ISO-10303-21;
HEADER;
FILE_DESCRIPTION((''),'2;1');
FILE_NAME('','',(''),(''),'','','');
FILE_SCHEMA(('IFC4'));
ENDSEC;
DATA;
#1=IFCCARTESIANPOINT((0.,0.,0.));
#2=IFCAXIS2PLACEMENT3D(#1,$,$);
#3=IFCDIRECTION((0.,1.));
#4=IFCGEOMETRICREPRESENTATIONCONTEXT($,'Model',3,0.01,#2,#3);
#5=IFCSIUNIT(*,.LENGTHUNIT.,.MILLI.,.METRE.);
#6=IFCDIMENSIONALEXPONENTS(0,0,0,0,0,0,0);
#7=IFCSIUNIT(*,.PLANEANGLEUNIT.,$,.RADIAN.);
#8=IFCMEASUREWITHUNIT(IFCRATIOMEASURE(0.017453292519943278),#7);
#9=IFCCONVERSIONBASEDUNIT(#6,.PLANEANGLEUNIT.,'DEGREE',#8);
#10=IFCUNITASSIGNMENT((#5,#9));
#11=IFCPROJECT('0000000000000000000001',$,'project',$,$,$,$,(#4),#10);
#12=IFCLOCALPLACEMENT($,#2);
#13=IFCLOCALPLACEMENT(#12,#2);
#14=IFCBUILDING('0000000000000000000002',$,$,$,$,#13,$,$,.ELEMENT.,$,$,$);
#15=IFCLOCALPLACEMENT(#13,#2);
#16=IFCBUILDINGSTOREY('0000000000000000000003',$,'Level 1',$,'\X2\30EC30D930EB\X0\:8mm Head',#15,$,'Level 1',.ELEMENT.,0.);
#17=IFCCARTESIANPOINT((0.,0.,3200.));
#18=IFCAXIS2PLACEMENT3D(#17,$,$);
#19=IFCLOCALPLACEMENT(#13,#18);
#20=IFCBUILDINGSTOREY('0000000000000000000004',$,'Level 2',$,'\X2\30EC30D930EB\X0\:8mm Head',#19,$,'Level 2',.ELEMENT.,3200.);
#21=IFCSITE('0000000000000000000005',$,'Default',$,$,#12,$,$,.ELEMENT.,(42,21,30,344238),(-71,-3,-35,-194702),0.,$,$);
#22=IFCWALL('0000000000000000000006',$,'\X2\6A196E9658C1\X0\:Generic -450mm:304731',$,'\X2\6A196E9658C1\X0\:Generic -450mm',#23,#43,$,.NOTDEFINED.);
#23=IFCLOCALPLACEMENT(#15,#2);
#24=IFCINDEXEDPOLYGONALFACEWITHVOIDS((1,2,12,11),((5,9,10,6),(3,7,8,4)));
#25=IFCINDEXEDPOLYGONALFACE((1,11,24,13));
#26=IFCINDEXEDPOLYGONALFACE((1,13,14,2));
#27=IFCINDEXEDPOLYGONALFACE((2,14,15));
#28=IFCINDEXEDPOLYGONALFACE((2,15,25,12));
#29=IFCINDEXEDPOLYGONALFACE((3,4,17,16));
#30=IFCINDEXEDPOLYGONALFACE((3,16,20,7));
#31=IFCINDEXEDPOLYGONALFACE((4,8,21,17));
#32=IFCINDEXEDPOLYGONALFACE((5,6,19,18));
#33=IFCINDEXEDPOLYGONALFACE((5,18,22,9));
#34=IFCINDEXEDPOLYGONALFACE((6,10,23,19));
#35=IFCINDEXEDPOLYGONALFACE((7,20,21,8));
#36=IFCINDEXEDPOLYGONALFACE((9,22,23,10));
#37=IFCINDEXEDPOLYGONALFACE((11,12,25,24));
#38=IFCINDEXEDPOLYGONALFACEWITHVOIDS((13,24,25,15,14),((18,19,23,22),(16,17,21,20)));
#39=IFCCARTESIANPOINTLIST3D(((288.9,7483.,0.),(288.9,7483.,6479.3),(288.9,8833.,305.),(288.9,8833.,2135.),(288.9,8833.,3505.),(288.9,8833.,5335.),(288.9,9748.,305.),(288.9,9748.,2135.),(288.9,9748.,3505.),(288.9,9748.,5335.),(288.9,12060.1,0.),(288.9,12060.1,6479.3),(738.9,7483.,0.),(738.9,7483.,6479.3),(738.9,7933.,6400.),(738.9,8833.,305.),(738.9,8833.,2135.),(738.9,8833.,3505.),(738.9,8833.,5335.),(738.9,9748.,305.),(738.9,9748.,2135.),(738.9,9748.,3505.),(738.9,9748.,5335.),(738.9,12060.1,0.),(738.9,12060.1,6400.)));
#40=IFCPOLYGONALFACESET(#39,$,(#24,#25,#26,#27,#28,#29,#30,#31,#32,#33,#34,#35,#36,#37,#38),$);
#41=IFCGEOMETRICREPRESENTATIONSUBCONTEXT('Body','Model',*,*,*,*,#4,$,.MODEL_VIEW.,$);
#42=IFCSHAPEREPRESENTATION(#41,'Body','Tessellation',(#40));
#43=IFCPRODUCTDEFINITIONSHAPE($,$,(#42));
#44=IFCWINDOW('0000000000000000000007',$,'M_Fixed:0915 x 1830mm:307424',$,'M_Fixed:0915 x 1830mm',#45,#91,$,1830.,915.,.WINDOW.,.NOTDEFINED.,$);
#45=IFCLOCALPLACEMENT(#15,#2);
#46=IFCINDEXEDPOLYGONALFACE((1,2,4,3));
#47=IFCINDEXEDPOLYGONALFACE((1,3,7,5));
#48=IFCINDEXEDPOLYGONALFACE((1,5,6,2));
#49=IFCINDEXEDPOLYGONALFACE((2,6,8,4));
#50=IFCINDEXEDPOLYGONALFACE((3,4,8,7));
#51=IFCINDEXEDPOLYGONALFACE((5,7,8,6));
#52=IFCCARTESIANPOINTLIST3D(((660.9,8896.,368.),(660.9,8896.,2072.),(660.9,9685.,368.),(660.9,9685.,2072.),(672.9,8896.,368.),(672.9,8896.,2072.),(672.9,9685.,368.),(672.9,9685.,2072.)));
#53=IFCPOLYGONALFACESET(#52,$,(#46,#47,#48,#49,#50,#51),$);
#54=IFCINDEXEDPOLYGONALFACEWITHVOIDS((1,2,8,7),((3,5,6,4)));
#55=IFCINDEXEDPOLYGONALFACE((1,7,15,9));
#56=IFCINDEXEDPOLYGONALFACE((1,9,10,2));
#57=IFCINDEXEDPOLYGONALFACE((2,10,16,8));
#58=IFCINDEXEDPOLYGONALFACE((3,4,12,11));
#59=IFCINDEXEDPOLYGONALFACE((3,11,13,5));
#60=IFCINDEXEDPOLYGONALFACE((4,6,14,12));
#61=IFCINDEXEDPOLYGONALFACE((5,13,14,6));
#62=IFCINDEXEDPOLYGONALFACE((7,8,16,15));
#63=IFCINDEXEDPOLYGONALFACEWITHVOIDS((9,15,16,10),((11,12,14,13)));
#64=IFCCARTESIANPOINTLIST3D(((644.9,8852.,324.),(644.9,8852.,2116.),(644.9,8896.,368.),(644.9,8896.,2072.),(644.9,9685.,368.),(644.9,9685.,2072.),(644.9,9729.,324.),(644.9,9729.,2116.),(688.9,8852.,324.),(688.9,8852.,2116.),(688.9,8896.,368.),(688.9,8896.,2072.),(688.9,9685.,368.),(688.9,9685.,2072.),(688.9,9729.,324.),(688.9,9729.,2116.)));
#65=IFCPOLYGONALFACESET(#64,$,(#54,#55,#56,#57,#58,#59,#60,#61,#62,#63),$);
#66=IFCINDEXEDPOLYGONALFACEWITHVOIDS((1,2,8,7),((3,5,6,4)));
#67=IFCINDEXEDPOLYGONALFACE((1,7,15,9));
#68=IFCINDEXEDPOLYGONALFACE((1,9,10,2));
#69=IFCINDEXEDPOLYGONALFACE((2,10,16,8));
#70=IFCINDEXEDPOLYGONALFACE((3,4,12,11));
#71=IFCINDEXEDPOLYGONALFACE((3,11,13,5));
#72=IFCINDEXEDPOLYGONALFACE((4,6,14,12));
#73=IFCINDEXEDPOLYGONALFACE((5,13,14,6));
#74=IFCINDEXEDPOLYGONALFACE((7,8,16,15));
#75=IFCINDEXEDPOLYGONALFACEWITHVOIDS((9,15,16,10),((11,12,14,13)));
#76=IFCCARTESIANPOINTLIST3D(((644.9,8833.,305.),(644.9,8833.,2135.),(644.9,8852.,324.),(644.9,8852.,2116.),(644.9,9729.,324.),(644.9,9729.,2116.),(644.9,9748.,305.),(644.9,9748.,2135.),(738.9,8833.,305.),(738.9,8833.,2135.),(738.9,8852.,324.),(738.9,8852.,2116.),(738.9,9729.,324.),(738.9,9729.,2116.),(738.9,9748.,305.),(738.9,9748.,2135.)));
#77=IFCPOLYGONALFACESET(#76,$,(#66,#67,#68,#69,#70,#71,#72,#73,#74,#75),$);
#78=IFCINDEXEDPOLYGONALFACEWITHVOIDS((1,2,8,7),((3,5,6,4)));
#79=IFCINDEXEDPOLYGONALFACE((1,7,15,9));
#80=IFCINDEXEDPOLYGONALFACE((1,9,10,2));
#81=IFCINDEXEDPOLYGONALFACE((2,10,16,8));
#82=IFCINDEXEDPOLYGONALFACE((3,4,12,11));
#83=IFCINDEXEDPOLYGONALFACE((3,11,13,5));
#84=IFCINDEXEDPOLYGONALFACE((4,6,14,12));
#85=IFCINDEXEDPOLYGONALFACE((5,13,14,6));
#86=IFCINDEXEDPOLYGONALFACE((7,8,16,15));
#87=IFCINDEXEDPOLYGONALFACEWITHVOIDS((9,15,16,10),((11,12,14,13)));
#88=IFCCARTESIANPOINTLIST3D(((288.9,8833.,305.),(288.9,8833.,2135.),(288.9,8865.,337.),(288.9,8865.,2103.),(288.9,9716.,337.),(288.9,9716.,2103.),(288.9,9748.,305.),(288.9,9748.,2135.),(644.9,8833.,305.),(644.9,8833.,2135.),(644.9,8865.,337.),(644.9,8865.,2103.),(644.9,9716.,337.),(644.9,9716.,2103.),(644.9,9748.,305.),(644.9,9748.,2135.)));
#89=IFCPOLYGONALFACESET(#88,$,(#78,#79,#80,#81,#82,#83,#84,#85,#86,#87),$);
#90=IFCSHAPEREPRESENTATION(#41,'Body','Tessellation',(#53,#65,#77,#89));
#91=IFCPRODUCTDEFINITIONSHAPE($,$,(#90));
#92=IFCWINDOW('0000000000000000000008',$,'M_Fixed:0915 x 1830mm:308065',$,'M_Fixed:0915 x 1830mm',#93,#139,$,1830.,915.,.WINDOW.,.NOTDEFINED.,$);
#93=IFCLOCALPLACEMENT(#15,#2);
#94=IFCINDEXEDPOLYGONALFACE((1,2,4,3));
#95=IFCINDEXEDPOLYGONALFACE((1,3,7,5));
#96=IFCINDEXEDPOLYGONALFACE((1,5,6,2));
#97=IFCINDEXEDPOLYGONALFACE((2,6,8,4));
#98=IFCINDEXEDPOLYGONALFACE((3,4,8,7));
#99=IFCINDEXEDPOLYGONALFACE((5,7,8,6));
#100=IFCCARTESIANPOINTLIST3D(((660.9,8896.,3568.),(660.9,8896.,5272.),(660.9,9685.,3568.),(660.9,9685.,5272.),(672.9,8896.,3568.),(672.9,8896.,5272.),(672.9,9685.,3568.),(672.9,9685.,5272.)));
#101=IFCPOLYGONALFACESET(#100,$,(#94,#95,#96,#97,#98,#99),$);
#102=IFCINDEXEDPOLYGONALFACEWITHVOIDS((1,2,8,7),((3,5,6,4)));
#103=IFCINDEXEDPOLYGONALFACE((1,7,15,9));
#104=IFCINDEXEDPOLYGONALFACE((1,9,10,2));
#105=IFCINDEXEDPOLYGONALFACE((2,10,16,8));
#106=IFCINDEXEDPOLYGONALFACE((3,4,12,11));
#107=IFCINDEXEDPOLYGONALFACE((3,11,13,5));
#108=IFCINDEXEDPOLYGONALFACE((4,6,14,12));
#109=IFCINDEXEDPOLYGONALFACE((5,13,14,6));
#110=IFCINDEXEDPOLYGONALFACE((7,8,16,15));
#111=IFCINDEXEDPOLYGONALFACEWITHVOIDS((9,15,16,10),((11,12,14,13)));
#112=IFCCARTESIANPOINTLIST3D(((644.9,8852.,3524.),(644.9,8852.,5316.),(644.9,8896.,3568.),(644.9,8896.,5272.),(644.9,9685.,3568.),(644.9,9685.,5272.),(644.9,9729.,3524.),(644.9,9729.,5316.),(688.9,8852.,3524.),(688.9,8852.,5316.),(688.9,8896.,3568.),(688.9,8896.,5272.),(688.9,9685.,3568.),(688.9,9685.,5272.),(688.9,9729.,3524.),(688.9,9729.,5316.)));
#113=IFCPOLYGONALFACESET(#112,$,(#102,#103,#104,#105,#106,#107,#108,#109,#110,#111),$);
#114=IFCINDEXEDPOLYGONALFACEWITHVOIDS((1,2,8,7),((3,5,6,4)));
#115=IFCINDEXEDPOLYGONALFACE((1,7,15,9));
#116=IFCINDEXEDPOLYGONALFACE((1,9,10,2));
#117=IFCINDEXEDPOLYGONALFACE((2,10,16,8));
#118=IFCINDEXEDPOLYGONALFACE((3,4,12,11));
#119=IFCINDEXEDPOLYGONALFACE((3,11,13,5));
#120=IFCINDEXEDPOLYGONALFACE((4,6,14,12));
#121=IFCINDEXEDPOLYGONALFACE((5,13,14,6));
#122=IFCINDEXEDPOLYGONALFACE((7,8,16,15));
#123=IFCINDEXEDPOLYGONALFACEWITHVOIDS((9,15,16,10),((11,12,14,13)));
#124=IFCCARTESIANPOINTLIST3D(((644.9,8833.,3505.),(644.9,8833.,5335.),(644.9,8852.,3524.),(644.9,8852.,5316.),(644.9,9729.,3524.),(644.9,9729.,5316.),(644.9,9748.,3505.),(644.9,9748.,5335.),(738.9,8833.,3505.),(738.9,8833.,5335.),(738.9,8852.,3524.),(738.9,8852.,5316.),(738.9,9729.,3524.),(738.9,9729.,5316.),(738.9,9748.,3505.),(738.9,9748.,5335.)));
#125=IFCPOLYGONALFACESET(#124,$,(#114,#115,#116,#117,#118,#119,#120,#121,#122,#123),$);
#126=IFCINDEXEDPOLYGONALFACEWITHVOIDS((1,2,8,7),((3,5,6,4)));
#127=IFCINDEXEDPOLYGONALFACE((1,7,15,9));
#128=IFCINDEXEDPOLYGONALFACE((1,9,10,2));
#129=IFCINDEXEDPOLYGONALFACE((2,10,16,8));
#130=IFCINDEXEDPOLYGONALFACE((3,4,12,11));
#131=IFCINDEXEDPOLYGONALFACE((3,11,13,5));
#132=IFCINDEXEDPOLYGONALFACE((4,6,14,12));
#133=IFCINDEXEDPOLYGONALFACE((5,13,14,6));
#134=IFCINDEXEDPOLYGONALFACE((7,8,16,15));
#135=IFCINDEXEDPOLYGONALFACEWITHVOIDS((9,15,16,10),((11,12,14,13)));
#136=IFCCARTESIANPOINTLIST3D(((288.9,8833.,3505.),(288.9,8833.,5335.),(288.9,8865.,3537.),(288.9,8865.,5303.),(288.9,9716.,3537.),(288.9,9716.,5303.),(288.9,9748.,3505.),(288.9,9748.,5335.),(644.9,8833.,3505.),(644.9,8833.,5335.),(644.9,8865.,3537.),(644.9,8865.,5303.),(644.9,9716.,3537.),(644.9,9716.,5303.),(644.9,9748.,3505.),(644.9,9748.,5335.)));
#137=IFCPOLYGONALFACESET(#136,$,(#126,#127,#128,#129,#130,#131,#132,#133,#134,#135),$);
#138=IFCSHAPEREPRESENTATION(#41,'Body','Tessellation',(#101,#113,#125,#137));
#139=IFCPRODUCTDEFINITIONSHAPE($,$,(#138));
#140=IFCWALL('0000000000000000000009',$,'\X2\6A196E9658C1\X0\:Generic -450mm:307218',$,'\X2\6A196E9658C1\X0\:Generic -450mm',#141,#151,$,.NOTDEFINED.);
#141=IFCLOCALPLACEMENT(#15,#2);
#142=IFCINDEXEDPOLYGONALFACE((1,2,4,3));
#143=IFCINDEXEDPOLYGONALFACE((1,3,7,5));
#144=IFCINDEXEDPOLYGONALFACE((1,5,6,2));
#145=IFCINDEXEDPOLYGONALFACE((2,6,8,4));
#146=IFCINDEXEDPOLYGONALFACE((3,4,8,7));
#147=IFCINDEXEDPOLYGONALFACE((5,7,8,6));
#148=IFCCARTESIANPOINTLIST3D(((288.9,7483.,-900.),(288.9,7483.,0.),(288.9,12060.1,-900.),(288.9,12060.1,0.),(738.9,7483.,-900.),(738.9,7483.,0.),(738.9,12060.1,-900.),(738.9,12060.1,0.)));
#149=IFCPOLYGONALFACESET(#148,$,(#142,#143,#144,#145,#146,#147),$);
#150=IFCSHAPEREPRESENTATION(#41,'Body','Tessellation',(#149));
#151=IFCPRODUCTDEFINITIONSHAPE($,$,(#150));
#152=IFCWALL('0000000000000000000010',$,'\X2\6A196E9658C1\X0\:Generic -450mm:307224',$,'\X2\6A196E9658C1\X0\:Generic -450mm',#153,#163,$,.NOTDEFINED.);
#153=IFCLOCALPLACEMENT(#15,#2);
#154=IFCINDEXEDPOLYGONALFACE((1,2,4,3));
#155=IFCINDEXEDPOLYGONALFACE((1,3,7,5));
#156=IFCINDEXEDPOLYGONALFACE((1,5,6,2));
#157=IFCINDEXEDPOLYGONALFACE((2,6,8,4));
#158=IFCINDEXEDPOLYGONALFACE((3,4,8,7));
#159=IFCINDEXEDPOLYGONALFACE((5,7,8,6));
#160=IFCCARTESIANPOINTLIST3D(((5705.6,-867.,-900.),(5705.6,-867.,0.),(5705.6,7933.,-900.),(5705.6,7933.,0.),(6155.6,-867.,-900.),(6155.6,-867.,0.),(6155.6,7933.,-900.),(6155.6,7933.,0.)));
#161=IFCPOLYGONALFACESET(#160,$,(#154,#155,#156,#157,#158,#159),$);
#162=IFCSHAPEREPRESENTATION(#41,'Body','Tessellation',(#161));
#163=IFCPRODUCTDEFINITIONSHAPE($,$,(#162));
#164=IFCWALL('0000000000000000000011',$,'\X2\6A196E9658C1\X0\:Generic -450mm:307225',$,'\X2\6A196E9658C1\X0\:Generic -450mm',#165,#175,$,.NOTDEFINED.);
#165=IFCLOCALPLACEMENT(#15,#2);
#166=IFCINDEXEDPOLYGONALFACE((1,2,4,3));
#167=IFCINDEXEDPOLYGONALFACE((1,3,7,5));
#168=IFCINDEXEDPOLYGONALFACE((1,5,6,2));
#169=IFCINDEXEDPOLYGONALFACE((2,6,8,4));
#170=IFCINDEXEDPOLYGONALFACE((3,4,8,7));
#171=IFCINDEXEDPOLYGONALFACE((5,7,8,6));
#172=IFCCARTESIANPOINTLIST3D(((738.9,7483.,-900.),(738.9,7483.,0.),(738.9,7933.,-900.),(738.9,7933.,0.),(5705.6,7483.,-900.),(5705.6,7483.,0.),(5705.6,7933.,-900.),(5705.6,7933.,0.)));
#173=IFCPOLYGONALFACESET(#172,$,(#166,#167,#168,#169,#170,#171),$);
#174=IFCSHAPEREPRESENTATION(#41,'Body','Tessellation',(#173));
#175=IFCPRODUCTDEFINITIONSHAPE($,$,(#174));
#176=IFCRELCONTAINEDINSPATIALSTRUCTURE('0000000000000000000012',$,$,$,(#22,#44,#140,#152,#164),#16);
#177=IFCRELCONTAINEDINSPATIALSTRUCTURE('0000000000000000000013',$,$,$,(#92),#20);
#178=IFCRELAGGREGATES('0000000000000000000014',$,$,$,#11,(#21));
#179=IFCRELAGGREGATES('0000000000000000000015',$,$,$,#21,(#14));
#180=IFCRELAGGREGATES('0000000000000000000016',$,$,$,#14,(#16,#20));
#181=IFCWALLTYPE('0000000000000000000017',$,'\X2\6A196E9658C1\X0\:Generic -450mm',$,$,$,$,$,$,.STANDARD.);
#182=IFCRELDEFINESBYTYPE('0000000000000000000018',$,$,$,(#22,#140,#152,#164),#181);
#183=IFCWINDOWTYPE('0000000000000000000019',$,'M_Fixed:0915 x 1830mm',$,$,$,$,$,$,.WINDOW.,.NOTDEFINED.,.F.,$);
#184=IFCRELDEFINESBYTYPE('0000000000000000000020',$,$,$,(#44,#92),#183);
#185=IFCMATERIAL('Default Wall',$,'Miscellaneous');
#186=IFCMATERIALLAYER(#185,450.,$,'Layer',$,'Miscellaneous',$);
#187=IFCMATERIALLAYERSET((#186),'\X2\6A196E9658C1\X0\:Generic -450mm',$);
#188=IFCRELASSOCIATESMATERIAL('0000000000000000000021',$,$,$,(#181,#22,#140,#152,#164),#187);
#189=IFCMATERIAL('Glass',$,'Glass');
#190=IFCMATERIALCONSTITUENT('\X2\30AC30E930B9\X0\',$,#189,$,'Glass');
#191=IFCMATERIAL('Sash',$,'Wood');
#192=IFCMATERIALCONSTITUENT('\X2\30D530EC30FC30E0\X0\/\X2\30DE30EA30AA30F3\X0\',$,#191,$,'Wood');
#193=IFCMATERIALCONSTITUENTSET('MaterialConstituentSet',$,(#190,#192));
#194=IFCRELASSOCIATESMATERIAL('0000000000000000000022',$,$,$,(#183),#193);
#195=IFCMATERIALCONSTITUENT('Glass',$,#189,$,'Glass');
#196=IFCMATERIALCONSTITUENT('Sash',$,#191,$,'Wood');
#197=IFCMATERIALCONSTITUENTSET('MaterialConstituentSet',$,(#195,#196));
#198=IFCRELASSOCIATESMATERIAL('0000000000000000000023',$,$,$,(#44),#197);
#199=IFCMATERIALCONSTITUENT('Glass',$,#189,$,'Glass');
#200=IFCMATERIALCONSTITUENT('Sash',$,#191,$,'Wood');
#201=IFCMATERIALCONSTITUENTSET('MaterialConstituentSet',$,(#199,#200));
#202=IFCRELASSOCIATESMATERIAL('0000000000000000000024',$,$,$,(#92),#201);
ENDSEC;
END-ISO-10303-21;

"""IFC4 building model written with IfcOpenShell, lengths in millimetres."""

from ifc_helpers import new_model, entity, si_unit, converted_unit, direction, frame, frame_2d, origin, origin_2d_with_axis, place, context, subcontext, project, spatial, polyline, rectangle, outline, extrude, clip, bounded_halfspace, source, transform, mapped, material, layer, layer_set, layer_usage, constituent, constituent_set, type_object, type_shapes, element, fill, save


model = new_model("IFC4")

# Units and contexts
model_context = context("Model", 3, precision=0.01, world=origin(), true_north=direction((0.0, 1.0)))
body_context = subcontext(model_context, "Body", "Model", "MODEL_VIEW")
ifc_project = project(units=[si_unit("LENGTHUNIT", "METRE", prefix="MILLI"), converted_unit("PLANEANGLEUNIT", "DEGREE", entity("IfcRatioMeasure", 0.017453292519943278), si_unit("PLANEANGLEUNIT", "RADIAN"), dimensions=[0, 0, 0, 0, 0, 0, 0])], contexts=[model_context])

# Site, building, storey
site_placement = place(None, origin())
site = spatial("IfcSite", under=ifc_project, at=site_placement, Name="Default", CompositionType="ELEMENT", RefLatitude=(42, 21, 30, 344238), RefLongitude=(-71, -3, -35, -194702), RefElevation=0.0)
building_placement = place(site_placement, origin())
building = spatial("IfcBuilding", under=site, at=building_placement, CompositionType="ELEMENT")
storey_1_placement = place(building_placement, origin())
storey_1 = spatial("IfcBuildingStorey", under=building, at=storey_1_placement, Name="Level 1", ObjectType="レベル:8mm Head", LongName="Level 1", CompositionType="ELEMENT", Elevation=0.0)

# Wall, openings, window
ifc_material_1 = material(Name="Default Wall", Category="Miscellaneous")
ifc_layer_1 = layer(ifc_material_1, 450.0, Name="Layer", Category="Miscellaneous")
ifc_layer_set_1 = layer_set([ifc_layer_1], Name="標準壁:Generic -450mm")
ifc_layer_usage_1 = layer_usage(ifc_layer_set_1, "AXIS2", "NEGATIVE", 225.0)
wall_type_1 = type_object("IfcWallType", Name="標準壁:Generic -450mm", PredefinedType="STANDARD", material=ifc_layer_set_1)
wall_1_placement = place(storey_1_placement, frame((513.9, 12060.1, 0.0), z_axis=(0.0, 0.0, 1.0), x_axis=(0.0, -1.0, 0.0)))
wall_1 = element("IfcWall", 1, at=wall_1_placement, inside=storey_1, type_object=wall_type_1, material=ifc_layer_usage_1, Name="標準壁:Generic -450mm:304731", ObjectType="標準壁:Generic -450mm", PredefinedType="NOTDEFINED", context=body_context, shape_type="Clipping", body=[
    clip(clip(extrude(rectangle(XDim=4577.1, YDim=450.0, at=frame_2d((2288.5, 0.0), x_axis=(-1.0, 0.0))), origin(), (0.0, 0.0, 1.0), 6479.3), bounded_halfspace(frame((4577.1, -225.0, 6479.3), z_axis=(-0.173648, 0.0, 0.984808), x_axis=(0.0, -1.0, 0.0)), False, frame((4577.1, -225.0, 6479.3)), polyline([(0.0, 0.0), (0.0, 450.0), (-450.0, 450.0), (0.0, 0.0)]))), bounded_halfspace(frame((0.0, -225.0, 6479.3), z_axis=(0.0, 0.173648, 0.984808), x_axis=(-1.0, 0.0, 0.0)), False, frame((0.0, -225.0, 6479.3)), polyline([(0.0, 0.0), (4577.1, 0.0), (4127.1, 450.0), (0.0, 450.0), (0.0, 0.0)]))),
])
opening_1_placement = place(wall_1_placement, frame((2312.1, -225.0, 305.0)))
opening_1 = element("IfcOpeningElement", 2, at=opening_1_placement, cuts=wall_1, PredefinedType="OPENING", context=body_context, shape_type="SweptSolid", body=[
    extrude(rectangle(XDim=1830.0, YDim=915.0, at=frame_2d((915.0, 457.5), x_axis=(1.0, 0.0))), frame((0.0, 0.0, 0.0), z_axis=(0.0, 1.0, 0.0), x_axis=(0.0, 0.0, 1.0)), (0.0, 0.0, 1.0), 450.0),
])
opening_2_placement = place(wall_1_placement, frame((2312.1, -225.0, 3505.0)))
opening_2 = element("IfcOpeningElement", 3, at=opening_2_placement, cuts=wall_1, PredefinedType="OPENING", context=body_context, shape_type="SweptSolid", body=[
    extrude(rectangle(XDim=1830.0, YDim=915.0, at=frame_2d((915.0, 457.5), x_axis=(1.0, 0.0))), frame((0.0, 0.0, 0.0), z_axis=(0.0, 1.0, 0.0), x_axis=(0.0, 0.0, 1.0)), (0.0, 0.0, 1.0), 450.0),
])
ifc_material_2 = material(Name="Glass", Category="Glass")
ifc_constituent_1 = constituent(ifc_material_2, Name="Glass", Category="Glass")
ifc_material_3 = material(Name="Sash", Category="Wood")
ifc_constituent_2 = constituent(ifc_material_3, Name="Sash", Category="Wood")
ifc_constituent_set_1 = constituent_set(constituents=[ifc_constituent_1, ifc_constituent_2], Name="MaterialConstituentSet")
ifc_constituent_3 = constituent(ifc_material_2, Name="ガラス", Category="Glass")
ifc_constituent_4 = constituent(ifc_material_3, Name="フレーム/マリオン", Category="Wood")
ifc_constituent_set_2 = constituent_set(constituents=[ifc_constituent_3, ifc_constituent_4], Name="MaterialConstituentSet")
window_type_1 = type_object("IfcWindowType", Name="M_Fixed:0915 x 1830mm", ParameterTakesPrecedence=False, PartitioningType="NOTDEFINED", PredefinedType="WINDOW", material=ifc_constituent_set_2)
shared_shape_1 = source(origin(), body_context, "Body", "SweptSolid", [
    extrude(rectangle(XDim=12.0, YDim=789.0, at=origin_2d_with_axis()), frame((457.5, 378.0, 63.0), z_axis=(0.0, 0.0, 1.0), x_axis=(0.0, -1.0, 0.0)), (0.0, 0.0, 1.0), 1704.0),
    extrude(outline(polyline([(-438.5, -896.0), (438.5, -896.0), (438.5, 896.0), (-438.5, 896.0), (-438.5, -896.0)]), holes=[polyline([(-394.5, -852.0), (-394.5, 852.0), (394.5, 852.0), (394.5, -852.0), (-394.5, -852.0)])]), frame((457.5, 356.0, 915.0), z_axis=(0.0, 1.0, 0.0), x_axis=(1.0, 0.0, 0.0)), (0.0, 0.0, 1.0), 44.0),
    extrude(outline(polyline([(-457.5, -915.0), (457.5, -915.0), (457.5, 915.0), (-457.5, 915.0), (-457.5, -915.0)]), holes=[polyline([(-438.5, -896.0), (-438.5, 896.0), (438.5, 896.0), (438.5, -896.0), (-438.5, -896.0)])]), frame((457.5, 356.0, 915.0), z_axis=(0.0, 1.0, 0.0), x_axis=(1.0, 0.0, 0.0)), (0.0, 0.0, 1.0), 94.0),
    extrude(outline(polyline([(-457.5, -915.0), (457.5, -915.0), (457.5, 915.0), (-457.5, 915.0), (-457.5, -915.0)]), holes=[polyline([(-425.5, -883.0), (-425.5, 883.0), (425.5, 883.0), (425.5, -883.0), (-425.5, -883.0)])]), frame((457.5, 0.0, 915.0), z_axis=(0.0, 1.0, 0.0), x_axis=(1.0, 0.0, 0.0)), (0.0, 0.0, 1.0), 356.0),
])
type_shapes(window_type_1, [shared_shape_1])
window_1_placement = place(opening_1_placement, origin())
window_1 = element("IfcWindow", 4, at=window_1_placement, inside=storey_1, type_object=window_type_1, material=ifc_constituent_set_1, Name="M_Fixed:0915 x 1830mm:307424", ObjectType="M_Fixed:0915 x 1830mm", OverallHeight=1830.0, OverallWidth=915.0, PartitioningType="NOTDEFINED", PredefinedType="WINDOW", context=body_context, shape_type="MappedRepresentation", body=[
    mapped(shared_shape_1, transform((0.0, 0.0, 0.0), scale=1.0)),
])
fill(opening_1, window_1)

# Shared definitions
storey_2_placement = place(building_placement, frame((0.0, 0.0, 3200.0)))
storey_2 = spatial("IfcBuildingStorey", under=building, at=storey_2_placement, Name="Level 2", ObjectType="レベル:8mm Head", LongName="Level 2", CompositionType="ELEMENT", Elevation=3200.0)

# Window
ifc_constituent_5 = constituent(ifc_material_2, Name="Glass", Category="Glass")
ifc_constituent_6 = constituent(ifc_material_3, Name="Sash", Category="Wood")
ifc_constituent_set_3 = constituent_set(constituents=[ifc_constituent_5, ifc_constituent_6], Name="MaterialConstituentSet")
window_2_placement = place(opening_2_placement, origin())
window_2 = element("IfcWindow", 5, at=window_2_placement, inside=storey_2, type_object=window_type_1, material=ifc_constituent_set_3, Name="M_Fixed:0915 x 1830mm:308065", ObjectType="M_Fixed:0915 x 1830mm", OverallHeight=1830.0, OverallWidth=915.0, PartitioningType="NOTDEFINED", PredefinedType="WINDOW", context=body_context, shape_type="MappedRepresentation", body=[
    mapped(shared_shape_1, transform((0.0, 0.0, 0.0), scale=1.0)),
])
fill(opening_2, window_2)

# Walls
ifc_layer_usage_2 = layer_usage(ifc_layer_set_1, "AXIS2", "NEGATIVE", 225.0)
wall_2_placement = place(storey_1_placement, frame((513.9, 12060.1, -900.0), z_axis=(0.0, 0.0, 1.0), x_axis=(0.0, -1.0, 0.0)))
element("IfcWall", 6, at=wall_2_placement, inside=storey_1, type_object=wall_type_1, material=ifc_layer_usage_2, Name="標準壁:Generic -450mm:307218", ObjectType="標準壁:Generic -450mm", PredefinedType="NOTDEFINED", context=body_context, shape_type="SweptSolid", body=[
    extrude(rectangle(XDim=4577.1, YDim=450.0, at=frame_2d((2288.5, 0.0), x_axis=(-1.0, 0.0))), origin(), (0.0, 0.0, 1.0), 900.0),
])
ifc_layer_usage_3 = layer_usage(ifc_layer_set_1, "AXIS2", "NEGATIVE", 225.0)
wall_3_placement = place(storey_1_placement, frame((5930.6, 7933.0, -900.0), z_axis=(0.0, 0.0, 1.0), x_axis=(0.0, -1.0, 0.0)))
element("IfcWall", 7, at=wall_3_placement, inside=storey_1, type_object=wall_type_1, material=ifc_layer_usage_3, Name="標準壁:Generic -450mm:307224", ObjectType="標準壁:Generic -450mm", PredefinedType="NOTDEFINED", context=body_context, shape_type="SweptSolid", body=[
    extrude(rectangle(XDim=8800.0, YDim=450.0, at=frame_2d((4400.0, 0.0), x_axis=(-1.0, 0.0))), origin(), (0.0, 0.0, 1.0), 900.0),
])
ifc_layer_usage_4 = layer_usage(ifc_layer_set_1, "AXIS2", "NEGATIVE", 225.0)
wall_4_placement = place(storey_1_placement, frame((738.9, 7708.0, -900.0)))
element("IfcWall", 8, at=wall_4_placement, inside=storey_1, type_object=wall_type_1, material=ifc_layer_usage_4, Name="標準壁:Generic -450mm:307225", ObjectType="標準壁:Generic -450mm", PredefinedType="NOTDEFINED", context=body_context, shape_type="SweptSolid", body=[
    extrude(rectangle(XDim=4966.7, YDim=450.0, at=frame_2d((2483.3, 0.0), x_axis=(-1.0, 0.0))), origin(), (0.0, 0.0, 1.0), 900.0),
])

save(model, "model.ifc")
